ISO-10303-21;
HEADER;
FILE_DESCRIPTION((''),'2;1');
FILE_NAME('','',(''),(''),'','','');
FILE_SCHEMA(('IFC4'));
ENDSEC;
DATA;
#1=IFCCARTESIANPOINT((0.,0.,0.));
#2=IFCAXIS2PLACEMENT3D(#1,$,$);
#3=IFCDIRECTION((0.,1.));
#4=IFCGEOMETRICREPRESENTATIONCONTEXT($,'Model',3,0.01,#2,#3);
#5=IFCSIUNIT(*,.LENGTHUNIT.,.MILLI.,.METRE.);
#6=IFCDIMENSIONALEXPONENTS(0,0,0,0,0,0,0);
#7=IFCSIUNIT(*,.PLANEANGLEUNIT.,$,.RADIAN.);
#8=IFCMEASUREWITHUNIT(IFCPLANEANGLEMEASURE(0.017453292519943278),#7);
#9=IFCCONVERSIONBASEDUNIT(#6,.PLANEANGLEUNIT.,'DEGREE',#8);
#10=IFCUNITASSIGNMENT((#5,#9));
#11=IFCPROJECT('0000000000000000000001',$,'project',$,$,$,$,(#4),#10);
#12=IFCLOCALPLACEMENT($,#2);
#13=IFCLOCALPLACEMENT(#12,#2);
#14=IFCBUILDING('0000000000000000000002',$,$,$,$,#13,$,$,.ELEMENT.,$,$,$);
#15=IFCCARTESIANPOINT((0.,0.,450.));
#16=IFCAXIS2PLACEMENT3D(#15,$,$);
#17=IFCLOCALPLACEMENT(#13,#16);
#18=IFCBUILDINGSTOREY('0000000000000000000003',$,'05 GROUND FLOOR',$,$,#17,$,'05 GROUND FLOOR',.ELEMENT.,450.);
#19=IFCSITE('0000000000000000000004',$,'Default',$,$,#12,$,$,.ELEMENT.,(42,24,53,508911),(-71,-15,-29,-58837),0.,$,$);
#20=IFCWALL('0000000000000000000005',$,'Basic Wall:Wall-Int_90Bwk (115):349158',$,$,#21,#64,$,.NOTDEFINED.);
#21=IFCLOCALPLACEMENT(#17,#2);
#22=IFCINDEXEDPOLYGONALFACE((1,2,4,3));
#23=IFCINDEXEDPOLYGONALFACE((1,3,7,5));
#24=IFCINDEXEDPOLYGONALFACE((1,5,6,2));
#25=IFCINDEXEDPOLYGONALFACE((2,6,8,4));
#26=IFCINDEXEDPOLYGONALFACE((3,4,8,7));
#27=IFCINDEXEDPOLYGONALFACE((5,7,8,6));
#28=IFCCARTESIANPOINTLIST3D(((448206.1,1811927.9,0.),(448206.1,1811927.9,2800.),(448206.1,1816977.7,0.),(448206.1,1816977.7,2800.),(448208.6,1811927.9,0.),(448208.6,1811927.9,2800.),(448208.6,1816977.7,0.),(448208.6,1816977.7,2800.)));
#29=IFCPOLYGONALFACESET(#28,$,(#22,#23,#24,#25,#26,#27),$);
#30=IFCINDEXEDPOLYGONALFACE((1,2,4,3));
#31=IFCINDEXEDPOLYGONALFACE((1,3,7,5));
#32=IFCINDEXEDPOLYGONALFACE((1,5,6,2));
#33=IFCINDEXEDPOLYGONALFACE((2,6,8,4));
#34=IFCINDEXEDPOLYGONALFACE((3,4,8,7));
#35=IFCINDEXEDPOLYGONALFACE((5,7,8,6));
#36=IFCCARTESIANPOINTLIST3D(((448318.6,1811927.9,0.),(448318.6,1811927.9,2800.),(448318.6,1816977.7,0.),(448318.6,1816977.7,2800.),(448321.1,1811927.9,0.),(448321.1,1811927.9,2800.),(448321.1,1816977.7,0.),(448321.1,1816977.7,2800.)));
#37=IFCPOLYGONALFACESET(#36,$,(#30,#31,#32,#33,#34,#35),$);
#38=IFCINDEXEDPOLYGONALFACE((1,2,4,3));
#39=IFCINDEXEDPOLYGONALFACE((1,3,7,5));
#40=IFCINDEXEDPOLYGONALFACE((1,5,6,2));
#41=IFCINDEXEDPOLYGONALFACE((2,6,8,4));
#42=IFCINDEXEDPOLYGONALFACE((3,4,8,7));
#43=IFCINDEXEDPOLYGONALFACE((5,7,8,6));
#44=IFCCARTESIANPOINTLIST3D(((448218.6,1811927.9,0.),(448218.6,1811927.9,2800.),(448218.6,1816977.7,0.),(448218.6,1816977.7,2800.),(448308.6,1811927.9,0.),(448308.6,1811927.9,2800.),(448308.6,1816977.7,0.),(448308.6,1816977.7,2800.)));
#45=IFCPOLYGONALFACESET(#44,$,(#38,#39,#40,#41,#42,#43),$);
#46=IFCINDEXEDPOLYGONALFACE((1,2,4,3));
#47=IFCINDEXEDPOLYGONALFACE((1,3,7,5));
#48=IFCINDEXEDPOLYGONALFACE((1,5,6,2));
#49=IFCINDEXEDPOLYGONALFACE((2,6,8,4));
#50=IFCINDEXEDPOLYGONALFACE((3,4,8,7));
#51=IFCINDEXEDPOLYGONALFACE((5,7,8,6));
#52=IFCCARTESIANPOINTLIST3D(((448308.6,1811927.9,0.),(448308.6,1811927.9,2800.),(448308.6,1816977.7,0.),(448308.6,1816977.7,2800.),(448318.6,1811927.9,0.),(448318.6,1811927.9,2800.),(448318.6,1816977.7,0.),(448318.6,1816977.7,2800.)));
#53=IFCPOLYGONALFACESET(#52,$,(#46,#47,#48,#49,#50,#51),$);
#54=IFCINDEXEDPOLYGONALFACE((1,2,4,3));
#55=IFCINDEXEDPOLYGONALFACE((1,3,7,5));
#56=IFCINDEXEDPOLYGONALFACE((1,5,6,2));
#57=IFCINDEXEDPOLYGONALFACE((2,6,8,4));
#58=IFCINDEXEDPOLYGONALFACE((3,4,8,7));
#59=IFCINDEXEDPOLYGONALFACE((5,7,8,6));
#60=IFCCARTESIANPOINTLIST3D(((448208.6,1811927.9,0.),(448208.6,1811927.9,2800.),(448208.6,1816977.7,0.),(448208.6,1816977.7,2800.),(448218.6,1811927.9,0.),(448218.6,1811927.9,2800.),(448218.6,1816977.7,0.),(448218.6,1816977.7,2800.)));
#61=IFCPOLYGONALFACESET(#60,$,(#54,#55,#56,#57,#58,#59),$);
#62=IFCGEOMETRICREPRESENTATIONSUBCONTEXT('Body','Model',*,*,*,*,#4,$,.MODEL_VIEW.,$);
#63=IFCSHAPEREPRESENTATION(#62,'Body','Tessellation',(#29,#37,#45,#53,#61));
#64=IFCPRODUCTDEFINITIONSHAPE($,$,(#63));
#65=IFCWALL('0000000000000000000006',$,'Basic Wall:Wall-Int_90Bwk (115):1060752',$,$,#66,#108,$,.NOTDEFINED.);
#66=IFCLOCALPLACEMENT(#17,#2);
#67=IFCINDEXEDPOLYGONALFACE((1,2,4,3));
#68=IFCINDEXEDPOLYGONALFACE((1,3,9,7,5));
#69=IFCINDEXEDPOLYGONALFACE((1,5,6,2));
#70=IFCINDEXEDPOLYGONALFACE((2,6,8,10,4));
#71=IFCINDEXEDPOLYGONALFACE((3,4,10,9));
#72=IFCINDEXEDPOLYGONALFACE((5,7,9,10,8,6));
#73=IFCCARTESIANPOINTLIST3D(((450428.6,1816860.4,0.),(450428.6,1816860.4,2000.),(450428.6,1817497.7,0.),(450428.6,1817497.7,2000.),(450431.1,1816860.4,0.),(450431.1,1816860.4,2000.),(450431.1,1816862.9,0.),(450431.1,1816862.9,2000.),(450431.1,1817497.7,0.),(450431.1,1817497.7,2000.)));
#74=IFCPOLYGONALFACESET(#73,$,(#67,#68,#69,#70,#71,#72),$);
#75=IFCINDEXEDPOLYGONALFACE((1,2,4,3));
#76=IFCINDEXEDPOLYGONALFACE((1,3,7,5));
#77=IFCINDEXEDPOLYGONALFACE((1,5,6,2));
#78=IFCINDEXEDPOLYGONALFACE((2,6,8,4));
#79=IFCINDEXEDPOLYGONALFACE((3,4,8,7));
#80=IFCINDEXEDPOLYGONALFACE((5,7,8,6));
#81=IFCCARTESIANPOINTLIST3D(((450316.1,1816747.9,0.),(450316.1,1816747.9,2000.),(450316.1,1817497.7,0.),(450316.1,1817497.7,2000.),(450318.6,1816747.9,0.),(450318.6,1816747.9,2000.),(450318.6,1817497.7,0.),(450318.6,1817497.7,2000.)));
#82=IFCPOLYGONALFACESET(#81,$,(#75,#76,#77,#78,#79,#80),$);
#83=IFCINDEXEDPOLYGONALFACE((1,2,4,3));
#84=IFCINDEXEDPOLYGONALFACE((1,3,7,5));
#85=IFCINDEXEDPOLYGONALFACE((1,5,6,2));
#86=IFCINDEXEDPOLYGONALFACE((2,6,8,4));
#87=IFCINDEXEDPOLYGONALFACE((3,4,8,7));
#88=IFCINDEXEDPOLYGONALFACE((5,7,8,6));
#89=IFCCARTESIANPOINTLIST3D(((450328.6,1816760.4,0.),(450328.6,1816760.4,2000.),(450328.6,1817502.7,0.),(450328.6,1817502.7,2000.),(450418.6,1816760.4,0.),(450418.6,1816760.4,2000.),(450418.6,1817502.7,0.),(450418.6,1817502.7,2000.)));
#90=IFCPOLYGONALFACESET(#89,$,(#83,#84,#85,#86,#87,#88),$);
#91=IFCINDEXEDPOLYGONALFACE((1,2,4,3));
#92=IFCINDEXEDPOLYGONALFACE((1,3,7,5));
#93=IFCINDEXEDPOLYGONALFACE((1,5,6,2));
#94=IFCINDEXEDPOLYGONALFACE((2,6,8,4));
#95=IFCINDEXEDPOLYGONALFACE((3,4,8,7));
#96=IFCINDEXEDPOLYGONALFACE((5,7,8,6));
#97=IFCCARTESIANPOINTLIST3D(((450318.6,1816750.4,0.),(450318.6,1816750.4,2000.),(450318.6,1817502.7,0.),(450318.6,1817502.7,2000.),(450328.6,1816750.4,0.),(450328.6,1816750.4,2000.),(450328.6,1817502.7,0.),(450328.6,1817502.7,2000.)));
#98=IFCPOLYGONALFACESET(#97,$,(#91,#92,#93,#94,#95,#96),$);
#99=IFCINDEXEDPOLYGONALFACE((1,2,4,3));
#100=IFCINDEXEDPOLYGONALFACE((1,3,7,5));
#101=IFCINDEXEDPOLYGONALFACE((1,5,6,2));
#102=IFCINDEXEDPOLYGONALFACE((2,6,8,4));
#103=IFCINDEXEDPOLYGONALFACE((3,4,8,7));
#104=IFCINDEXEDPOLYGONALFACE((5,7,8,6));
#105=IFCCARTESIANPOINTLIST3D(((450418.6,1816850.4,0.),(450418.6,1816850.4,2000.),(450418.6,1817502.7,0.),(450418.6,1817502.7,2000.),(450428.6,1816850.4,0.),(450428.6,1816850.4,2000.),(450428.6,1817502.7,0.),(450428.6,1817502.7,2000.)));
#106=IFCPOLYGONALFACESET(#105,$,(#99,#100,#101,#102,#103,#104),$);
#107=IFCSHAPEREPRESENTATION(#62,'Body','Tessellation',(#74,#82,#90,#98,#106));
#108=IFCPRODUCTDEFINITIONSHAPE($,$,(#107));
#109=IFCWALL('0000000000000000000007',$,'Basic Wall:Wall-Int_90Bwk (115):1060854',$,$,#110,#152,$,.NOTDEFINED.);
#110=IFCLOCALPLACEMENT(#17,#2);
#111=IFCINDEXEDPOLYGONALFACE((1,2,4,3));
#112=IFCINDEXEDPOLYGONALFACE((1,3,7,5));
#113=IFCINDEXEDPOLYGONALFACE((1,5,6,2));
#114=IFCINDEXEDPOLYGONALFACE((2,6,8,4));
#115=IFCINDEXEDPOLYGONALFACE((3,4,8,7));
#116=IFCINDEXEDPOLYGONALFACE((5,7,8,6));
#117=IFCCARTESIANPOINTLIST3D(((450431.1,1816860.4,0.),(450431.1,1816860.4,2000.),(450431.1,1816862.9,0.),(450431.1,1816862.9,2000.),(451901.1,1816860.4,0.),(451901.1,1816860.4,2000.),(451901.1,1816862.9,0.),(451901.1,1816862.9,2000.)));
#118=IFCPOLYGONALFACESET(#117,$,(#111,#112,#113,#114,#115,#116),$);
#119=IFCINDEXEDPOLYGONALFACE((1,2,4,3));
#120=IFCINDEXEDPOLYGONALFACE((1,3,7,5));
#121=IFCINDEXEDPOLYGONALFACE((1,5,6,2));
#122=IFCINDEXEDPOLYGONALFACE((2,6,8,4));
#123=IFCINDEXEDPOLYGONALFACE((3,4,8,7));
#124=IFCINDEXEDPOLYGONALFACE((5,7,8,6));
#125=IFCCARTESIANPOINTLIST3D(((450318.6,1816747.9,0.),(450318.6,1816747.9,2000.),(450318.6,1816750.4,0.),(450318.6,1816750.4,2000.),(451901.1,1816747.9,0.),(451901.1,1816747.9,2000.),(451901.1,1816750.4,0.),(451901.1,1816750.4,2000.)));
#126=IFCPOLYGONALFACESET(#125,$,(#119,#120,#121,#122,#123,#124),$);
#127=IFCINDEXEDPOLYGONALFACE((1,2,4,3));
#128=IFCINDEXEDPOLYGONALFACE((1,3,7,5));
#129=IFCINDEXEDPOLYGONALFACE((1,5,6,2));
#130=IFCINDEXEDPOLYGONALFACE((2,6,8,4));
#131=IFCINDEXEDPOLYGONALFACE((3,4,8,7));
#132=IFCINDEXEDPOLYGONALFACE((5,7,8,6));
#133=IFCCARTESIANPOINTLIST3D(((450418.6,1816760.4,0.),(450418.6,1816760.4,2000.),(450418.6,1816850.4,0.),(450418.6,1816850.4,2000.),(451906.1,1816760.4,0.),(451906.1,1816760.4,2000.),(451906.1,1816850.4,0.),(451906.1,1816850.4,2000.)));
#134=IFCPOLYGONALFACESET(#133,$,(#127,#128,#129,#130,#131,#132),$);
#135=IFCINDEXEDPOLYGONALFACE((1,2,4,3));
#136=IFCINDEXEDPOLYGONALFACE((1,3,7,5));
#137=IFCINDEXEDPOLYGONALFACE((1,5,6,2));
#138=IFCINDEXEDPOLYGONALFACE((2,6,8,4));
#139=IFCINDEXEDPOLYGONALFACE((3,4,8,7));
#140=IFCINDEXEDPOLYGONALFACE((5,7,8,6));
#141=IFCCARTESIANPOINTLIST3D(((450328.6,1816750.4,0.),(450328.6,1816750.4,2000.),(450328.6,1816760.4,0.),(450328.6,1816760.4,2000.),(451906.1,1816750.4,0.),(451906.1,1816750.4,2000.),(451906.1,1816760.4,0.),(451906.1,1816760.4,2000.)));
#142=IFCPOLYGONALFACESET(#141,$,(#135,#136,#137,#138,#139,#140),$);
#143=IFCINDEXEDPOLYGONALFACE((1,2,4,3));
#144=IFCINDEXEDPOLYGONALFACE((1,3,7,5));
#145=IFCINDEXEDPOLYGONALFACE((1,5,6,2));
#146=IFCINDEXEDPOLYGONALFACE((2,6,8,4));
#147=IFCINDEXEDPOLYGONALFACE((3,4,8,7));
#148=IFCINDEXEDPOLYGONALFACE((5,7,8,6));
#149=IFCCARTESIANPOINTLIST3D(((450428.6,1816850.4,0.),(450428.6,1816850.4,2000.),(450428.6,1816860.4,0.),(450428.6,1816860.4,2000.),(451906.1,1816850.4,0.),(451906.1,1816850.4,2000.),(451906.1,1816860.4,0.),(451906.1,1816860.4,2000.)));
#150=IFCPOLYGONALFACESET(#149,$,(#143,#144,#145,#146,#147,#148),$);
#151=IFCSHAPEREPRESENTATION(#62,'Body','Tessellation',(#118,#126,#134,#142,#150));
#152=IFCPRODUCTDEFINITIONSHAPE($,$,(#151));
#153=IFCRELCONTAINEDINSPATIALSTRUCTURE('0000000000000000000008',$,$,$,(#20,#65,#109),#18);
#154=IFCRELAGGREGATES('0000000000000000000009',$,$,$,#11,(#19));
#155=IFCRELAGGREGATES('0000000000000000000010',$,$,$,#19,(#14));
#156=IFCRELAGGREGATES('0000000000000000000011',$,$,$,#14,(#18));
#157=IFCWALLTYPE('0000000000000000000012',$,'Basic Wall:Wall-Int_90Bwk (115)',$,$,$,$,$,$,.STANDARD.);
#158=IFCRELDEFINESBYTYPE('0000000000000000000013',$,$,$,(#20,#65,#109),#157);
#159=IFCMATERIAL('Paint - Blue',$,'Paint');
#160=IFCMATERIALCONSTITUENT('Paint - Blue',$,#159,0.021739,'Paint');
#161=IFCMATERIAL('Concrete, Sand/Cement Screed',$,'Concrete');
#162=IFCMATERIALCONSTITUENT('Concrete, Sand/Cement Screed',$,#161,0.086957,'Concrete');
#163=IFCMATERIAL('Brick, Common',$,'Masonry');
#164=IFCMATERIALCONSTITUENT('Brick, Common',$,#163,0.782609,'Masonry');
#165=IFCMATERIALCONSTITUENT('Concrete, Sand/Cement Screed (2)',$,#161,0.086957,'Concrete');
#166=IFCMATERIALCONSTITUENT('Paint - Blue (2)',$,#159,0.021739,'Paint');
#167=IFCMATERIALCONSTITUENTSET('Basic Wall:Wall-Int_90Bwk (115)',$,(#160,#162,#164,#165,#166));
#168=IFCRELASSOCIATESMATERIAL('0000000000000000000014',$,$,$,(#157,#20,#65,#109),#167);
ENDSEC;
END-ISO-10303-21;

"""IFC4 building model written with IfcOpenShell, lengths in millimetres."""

from ifc_helpers import new_model, entity, si_unit, converted_unit, direction, frame, origin, place, context, subcontext, project, spatial, indexed_curve, outline, extrude, material, constituent, constituent_set, type_object, element, save


model = new_model("IFC4")

# Units and contexts
model_context = context("Model", 3, precision=0.01, world=origin(), true_north=direction((0.0, 1.0)))
body_context = subcontext(model_context, "Body", "Model", "MODEL_VIEW")
ifc_project = project(units=[si_unit("LENGTHUNIT", "METRE", prefix="MILLI"), converted_unit("PLANEANGLEUNIT", "DEGREE", entity("IfcPlaneAngleMeasure", 0.017453292519943278), si_unit("PLANEANGLEUNIT", "RADIAN"), dimensions=[0, 0, 0, 0, 0, 0, 0])], contexts=[model_context])

# Site, building, storey
site_placement = place(None, origin())
site = spatial("IfcSite", under=ifc_project, at=site_placement, Name="Default", CompositionType="ELEMENT", RefLatitude=(42, 24, 53, 508911), RefLongitude=(-71, -15, -29, -58837), RefElevation=0.0)
building_placement = place(site_placement, origin())
building = spatial("IfcBuilding", under=site, at=building_placement, CompositionType="ELEMENT")
storey_placement = place(building_placement, frame((0.0, 0.0, 450.0)))
storey = spatial("IfcBuildingStorey", under=building, at=storey_placement, Name="05 GROUND FLOOR", LongName="05 GROUND FLOOR", CompositionType="ELEMENT", Elevation=450.0)

# Shared definitions
ifc_material_1 = material(Name="Paint - Blue", Category="Paint")
ifc_constituent_1 = constituent(ifc_material_1, Name="Paint - Blue", Category="Paint", fraction=0.021739)
ifc_material_2 = material(Name="Concrete, Sand/Cement Screed", Category="Concrete")
ifc_constituent_2 = constituent(ifc_material_2, Name="Concrete, Sand/Cement Screed", Category="Concrete", fraction=0.086957)
ifc_material_3 = material(Name="Brick, Common", Category="Masonry")
ifc_constituent_3 = constituent(ifc_material_3, Name="Brick, Common", Category="Masonry", fraction=0.782609)
ifc_constituent_4 = constituent(ifc_material_2, Name="Concrete, Sand/Cement Screed (2)", Category="Concrete", fraction=0.086957)
ifc_constituent_5 = constituent(ifc_material_1, Name="Paint - Blue (2)", Category="Paint", fraction=0.021739)
ifc_constituent_set_1 = constituent_set(constituents=[ifc_constituent_1, ifc_constituent_2, ifc_constituent_3, ifc_constituent_4, ifc_constituent_5], Name="Basic Wall:Wall-Int_90Bwk (115)")
wall_type_1 = type_object("IfcWallType", Name="Basic Wall:Wall-Int_90Bwk (115)", PredefinedType="STANDARD", material=ifc_constituent_set_1)

# Walls
wall_1_placement = place(storey_placement, frame((448263.6, 1816977.7, 0.0), z_axis=(0.0, 0.0, 1.0), x_axis=(0.0, -1.0, 0.0)))
element("IfcWall", 1, at=wall_1_placement, inside=storey, type_object=wall_type_1, material=ifc_constituent_set_1, Name="Basic Wall:Wall-Int_90Bwk (115):349158", PredefinedType="NOTDEFINED", context=body_context, shape_type="SweptSolid", body=[
    extrude(outline(indexed_curve([(-1.3, -2524.9), (1.2, -2524.9), (1.2, 2524.9), (-1.3, 2524.9), (-1.3, -2524.9)], self_intersect=False)), frame((2524.9, -56.2, 0.0), z_axis=(0.0, 0.0, 1.0), x_axis=(0.0, 1.0, 0.0)), (0.0, 0.0, 1.0), 2800.0),
    extrude(outline(indexed_curve([(-1.3, -2524.9), (1.2, -2524.9), (1.2, 2524.9), (-1.3, 2524.9), (-1.3, -2524.9)], self_intersect=False)), frame((2524.9, 56.2, 0.0), z_axis=(0.0, 0.0, 1.0), x_axis=(0.0, -1.0, 0.0)), (0.0, 0.0, 1.0), 2800.0),
    extrude(outline(indexed_curve([(-2524.9, -45.0), (2524.9, -45.0), (2524.9, 45.0), (-2524.9, 45.0), (-2524.9, -45.0)], self_intersect=False)), frame((2524.9, 0.0, 0.0)), (0.0, 0.0, 1.0), 2800.0),
    extrude(outline(indexed_curve([(-2524.9, -5.0), (2524.9, -5.0), (2524.9, 5.0), (-2524.9, 5.0), (-2524.9, -5.0)], self_intersect=False)), frame((2524.9, 50.0, 0.0)), (0.0, 0.0, 1.0), 2800.0),
    extrude(outline(indexed_curve([(-2524.9, -5.0), (2524.9, -5.0), (2524.9, 5.0), (-2524.9, 5.0), (-2524.9, -5.0)], self_intersect=False)), frame((2524.9, -50.0, 0.0)), (0.0, 0.0, 1.0), 2800.0),
])
wall_2_placement = place(storey_placement, frame((450373.6, 1817497.7, 0.0), z_axis=(0.0, 0.0, 1.0), x_axis=(0.0, -1.0, 0.0)))
element("IfcWall", 2, at=wall_2_placement, inside=storey, type_object=wall_type_1, material=ifc_constituent_set_1, Name="Basic Wall:Wall-Int_90Bwk (115):1060752", PredefinedType="NOTDEFINED", context=body_context, shape_type="SweptSolid", body=[
    extrude(outline(indexed_curve([(-252.9, -1.0), (381.9, -1.0), (381.9, 1.5), (-255.4, 1.5), (-255.4, -1.0), (-252.9, -1.0)], self_intersect=False)), frame((381.9, 56.5, 0.0), z_axis=(0.0, 0.0, 1.0), x_axis=(-1.0, 0.0, 0.0)), (0.0, 0.0, 1.0), 2000.0),
    extrude(outline(indexed_curve([(-1.3, -374.9), (1.2, -374.9), (1.2, 374.9), (-1.3, 374.9), (-1.3, -374.9)], self_intersect=False)), frame((374.9, -56.2, 0.0), z_axis=(0.0, 0.0, 1.0), x_axis=(0.0, 1.0, 0.0)), (0.0, 0.0, 1.0), 2000.0),
    extrude(outline(indexed_curve([(-371.2, -45.0), (371.2, -45.0), (371.2, 45.0), (-371.2, 45.0), (-371.2, -45.0)], self_intersect=False)), frame((366.2, 0.0, 0.0)), (0.0, 0.0, 1.0), 2000.0),
    extrude(outline(indexed_curve([(-376.2, -5.0), (376.2, -5.0), (376.2, 5.0), (-376.2, 5.0), (-376.2, -5.0)], self_intersect=False)), frame((371.2, -50.0, 0.0)), (0.0, 0.0, 1.0), 2000.0),
    extrude(outline(indexed_curve([(-326.2, -5.0), (326.2, -5.0), (326.2, 5.0), (-326.2, 5.0), (-326.2, -5.0)], self_intersect=False)), frame((321.2, 50.0, 0.0)), (0.0, 0.0, 1.0), 2000.0),
])
wall_3_placement = place(storey_placement, frame((450431.1, 1816805.4, 0.0)))
element("IfcWall", 3, at=wall_3_placement, inside=storey, type_object=wall_type_1, material=ifc_constituent_set_1, Name="Basic Wall:Wall-Int_90Bwk (115):1060854", PredefinedType="NOTDEFINED", context=body_context, shape_type="SweptSolid", body=[
    extrude(outline(indexed_curve([(-1.3, -735.0), (1.3, -735.0), (1.3, 735.0), (-1.3, 735.0), (-1.3, -735.0)], self_intersect=False)), frame((735.0, 56.3, 0.0), z_axis=(0.0, 0.0, 1.0), x_axis=(0.0, -1.0, 0.0)), (0.0, 0.0, 1.0), 2000.0),
    extrude(outline(indexed_curve([(-1.2, -791.3), (1.3, -791.2), (1.3, 791.2), (-1.2, 791.2), (-1.2, -791.3)], self_intersect=False)), frame((678.7, -56.3, 0.0), z_axis=(0.0, 0.0, 1.0), x_axis=(0.0, 1.0, 0.0)), (0.0, 0.0, 1.0), 2000.0),
    extrude(outline(indexed_curve([(-743.7, -45.0), (743.7, -45.0), (743.7, 45.0), (-743.7, 45.0), (-743.7, -45.0)], self_intersect=False)), frame((731.2, 0.0, 0.0)), (0.0, 0.0, 1.0), 2000.0),
    extrude(outline(indexed_curve([(-788.8, -5.0), (788.8, -5.0), (788.8, 5.0), (-788.8, 5.0), (-788.8, -5.0)], self_intersect=False)), frame((686.2, -50.0, 0.0)), (0.0, 0.0, 1.0), 2000.0),
    extrude(outline(indexed_curve([(-738.7, -5.0), (738.7, -5.0), (738.7, 5.0), (-738.7, 5.0), (-738.7, -5.0)], self_intersect=False)), frame((736.3, 50.0, 0.0)), (0.0, 0.0, 1.0), 2000.0),
])

save(model, "model.ifc")
